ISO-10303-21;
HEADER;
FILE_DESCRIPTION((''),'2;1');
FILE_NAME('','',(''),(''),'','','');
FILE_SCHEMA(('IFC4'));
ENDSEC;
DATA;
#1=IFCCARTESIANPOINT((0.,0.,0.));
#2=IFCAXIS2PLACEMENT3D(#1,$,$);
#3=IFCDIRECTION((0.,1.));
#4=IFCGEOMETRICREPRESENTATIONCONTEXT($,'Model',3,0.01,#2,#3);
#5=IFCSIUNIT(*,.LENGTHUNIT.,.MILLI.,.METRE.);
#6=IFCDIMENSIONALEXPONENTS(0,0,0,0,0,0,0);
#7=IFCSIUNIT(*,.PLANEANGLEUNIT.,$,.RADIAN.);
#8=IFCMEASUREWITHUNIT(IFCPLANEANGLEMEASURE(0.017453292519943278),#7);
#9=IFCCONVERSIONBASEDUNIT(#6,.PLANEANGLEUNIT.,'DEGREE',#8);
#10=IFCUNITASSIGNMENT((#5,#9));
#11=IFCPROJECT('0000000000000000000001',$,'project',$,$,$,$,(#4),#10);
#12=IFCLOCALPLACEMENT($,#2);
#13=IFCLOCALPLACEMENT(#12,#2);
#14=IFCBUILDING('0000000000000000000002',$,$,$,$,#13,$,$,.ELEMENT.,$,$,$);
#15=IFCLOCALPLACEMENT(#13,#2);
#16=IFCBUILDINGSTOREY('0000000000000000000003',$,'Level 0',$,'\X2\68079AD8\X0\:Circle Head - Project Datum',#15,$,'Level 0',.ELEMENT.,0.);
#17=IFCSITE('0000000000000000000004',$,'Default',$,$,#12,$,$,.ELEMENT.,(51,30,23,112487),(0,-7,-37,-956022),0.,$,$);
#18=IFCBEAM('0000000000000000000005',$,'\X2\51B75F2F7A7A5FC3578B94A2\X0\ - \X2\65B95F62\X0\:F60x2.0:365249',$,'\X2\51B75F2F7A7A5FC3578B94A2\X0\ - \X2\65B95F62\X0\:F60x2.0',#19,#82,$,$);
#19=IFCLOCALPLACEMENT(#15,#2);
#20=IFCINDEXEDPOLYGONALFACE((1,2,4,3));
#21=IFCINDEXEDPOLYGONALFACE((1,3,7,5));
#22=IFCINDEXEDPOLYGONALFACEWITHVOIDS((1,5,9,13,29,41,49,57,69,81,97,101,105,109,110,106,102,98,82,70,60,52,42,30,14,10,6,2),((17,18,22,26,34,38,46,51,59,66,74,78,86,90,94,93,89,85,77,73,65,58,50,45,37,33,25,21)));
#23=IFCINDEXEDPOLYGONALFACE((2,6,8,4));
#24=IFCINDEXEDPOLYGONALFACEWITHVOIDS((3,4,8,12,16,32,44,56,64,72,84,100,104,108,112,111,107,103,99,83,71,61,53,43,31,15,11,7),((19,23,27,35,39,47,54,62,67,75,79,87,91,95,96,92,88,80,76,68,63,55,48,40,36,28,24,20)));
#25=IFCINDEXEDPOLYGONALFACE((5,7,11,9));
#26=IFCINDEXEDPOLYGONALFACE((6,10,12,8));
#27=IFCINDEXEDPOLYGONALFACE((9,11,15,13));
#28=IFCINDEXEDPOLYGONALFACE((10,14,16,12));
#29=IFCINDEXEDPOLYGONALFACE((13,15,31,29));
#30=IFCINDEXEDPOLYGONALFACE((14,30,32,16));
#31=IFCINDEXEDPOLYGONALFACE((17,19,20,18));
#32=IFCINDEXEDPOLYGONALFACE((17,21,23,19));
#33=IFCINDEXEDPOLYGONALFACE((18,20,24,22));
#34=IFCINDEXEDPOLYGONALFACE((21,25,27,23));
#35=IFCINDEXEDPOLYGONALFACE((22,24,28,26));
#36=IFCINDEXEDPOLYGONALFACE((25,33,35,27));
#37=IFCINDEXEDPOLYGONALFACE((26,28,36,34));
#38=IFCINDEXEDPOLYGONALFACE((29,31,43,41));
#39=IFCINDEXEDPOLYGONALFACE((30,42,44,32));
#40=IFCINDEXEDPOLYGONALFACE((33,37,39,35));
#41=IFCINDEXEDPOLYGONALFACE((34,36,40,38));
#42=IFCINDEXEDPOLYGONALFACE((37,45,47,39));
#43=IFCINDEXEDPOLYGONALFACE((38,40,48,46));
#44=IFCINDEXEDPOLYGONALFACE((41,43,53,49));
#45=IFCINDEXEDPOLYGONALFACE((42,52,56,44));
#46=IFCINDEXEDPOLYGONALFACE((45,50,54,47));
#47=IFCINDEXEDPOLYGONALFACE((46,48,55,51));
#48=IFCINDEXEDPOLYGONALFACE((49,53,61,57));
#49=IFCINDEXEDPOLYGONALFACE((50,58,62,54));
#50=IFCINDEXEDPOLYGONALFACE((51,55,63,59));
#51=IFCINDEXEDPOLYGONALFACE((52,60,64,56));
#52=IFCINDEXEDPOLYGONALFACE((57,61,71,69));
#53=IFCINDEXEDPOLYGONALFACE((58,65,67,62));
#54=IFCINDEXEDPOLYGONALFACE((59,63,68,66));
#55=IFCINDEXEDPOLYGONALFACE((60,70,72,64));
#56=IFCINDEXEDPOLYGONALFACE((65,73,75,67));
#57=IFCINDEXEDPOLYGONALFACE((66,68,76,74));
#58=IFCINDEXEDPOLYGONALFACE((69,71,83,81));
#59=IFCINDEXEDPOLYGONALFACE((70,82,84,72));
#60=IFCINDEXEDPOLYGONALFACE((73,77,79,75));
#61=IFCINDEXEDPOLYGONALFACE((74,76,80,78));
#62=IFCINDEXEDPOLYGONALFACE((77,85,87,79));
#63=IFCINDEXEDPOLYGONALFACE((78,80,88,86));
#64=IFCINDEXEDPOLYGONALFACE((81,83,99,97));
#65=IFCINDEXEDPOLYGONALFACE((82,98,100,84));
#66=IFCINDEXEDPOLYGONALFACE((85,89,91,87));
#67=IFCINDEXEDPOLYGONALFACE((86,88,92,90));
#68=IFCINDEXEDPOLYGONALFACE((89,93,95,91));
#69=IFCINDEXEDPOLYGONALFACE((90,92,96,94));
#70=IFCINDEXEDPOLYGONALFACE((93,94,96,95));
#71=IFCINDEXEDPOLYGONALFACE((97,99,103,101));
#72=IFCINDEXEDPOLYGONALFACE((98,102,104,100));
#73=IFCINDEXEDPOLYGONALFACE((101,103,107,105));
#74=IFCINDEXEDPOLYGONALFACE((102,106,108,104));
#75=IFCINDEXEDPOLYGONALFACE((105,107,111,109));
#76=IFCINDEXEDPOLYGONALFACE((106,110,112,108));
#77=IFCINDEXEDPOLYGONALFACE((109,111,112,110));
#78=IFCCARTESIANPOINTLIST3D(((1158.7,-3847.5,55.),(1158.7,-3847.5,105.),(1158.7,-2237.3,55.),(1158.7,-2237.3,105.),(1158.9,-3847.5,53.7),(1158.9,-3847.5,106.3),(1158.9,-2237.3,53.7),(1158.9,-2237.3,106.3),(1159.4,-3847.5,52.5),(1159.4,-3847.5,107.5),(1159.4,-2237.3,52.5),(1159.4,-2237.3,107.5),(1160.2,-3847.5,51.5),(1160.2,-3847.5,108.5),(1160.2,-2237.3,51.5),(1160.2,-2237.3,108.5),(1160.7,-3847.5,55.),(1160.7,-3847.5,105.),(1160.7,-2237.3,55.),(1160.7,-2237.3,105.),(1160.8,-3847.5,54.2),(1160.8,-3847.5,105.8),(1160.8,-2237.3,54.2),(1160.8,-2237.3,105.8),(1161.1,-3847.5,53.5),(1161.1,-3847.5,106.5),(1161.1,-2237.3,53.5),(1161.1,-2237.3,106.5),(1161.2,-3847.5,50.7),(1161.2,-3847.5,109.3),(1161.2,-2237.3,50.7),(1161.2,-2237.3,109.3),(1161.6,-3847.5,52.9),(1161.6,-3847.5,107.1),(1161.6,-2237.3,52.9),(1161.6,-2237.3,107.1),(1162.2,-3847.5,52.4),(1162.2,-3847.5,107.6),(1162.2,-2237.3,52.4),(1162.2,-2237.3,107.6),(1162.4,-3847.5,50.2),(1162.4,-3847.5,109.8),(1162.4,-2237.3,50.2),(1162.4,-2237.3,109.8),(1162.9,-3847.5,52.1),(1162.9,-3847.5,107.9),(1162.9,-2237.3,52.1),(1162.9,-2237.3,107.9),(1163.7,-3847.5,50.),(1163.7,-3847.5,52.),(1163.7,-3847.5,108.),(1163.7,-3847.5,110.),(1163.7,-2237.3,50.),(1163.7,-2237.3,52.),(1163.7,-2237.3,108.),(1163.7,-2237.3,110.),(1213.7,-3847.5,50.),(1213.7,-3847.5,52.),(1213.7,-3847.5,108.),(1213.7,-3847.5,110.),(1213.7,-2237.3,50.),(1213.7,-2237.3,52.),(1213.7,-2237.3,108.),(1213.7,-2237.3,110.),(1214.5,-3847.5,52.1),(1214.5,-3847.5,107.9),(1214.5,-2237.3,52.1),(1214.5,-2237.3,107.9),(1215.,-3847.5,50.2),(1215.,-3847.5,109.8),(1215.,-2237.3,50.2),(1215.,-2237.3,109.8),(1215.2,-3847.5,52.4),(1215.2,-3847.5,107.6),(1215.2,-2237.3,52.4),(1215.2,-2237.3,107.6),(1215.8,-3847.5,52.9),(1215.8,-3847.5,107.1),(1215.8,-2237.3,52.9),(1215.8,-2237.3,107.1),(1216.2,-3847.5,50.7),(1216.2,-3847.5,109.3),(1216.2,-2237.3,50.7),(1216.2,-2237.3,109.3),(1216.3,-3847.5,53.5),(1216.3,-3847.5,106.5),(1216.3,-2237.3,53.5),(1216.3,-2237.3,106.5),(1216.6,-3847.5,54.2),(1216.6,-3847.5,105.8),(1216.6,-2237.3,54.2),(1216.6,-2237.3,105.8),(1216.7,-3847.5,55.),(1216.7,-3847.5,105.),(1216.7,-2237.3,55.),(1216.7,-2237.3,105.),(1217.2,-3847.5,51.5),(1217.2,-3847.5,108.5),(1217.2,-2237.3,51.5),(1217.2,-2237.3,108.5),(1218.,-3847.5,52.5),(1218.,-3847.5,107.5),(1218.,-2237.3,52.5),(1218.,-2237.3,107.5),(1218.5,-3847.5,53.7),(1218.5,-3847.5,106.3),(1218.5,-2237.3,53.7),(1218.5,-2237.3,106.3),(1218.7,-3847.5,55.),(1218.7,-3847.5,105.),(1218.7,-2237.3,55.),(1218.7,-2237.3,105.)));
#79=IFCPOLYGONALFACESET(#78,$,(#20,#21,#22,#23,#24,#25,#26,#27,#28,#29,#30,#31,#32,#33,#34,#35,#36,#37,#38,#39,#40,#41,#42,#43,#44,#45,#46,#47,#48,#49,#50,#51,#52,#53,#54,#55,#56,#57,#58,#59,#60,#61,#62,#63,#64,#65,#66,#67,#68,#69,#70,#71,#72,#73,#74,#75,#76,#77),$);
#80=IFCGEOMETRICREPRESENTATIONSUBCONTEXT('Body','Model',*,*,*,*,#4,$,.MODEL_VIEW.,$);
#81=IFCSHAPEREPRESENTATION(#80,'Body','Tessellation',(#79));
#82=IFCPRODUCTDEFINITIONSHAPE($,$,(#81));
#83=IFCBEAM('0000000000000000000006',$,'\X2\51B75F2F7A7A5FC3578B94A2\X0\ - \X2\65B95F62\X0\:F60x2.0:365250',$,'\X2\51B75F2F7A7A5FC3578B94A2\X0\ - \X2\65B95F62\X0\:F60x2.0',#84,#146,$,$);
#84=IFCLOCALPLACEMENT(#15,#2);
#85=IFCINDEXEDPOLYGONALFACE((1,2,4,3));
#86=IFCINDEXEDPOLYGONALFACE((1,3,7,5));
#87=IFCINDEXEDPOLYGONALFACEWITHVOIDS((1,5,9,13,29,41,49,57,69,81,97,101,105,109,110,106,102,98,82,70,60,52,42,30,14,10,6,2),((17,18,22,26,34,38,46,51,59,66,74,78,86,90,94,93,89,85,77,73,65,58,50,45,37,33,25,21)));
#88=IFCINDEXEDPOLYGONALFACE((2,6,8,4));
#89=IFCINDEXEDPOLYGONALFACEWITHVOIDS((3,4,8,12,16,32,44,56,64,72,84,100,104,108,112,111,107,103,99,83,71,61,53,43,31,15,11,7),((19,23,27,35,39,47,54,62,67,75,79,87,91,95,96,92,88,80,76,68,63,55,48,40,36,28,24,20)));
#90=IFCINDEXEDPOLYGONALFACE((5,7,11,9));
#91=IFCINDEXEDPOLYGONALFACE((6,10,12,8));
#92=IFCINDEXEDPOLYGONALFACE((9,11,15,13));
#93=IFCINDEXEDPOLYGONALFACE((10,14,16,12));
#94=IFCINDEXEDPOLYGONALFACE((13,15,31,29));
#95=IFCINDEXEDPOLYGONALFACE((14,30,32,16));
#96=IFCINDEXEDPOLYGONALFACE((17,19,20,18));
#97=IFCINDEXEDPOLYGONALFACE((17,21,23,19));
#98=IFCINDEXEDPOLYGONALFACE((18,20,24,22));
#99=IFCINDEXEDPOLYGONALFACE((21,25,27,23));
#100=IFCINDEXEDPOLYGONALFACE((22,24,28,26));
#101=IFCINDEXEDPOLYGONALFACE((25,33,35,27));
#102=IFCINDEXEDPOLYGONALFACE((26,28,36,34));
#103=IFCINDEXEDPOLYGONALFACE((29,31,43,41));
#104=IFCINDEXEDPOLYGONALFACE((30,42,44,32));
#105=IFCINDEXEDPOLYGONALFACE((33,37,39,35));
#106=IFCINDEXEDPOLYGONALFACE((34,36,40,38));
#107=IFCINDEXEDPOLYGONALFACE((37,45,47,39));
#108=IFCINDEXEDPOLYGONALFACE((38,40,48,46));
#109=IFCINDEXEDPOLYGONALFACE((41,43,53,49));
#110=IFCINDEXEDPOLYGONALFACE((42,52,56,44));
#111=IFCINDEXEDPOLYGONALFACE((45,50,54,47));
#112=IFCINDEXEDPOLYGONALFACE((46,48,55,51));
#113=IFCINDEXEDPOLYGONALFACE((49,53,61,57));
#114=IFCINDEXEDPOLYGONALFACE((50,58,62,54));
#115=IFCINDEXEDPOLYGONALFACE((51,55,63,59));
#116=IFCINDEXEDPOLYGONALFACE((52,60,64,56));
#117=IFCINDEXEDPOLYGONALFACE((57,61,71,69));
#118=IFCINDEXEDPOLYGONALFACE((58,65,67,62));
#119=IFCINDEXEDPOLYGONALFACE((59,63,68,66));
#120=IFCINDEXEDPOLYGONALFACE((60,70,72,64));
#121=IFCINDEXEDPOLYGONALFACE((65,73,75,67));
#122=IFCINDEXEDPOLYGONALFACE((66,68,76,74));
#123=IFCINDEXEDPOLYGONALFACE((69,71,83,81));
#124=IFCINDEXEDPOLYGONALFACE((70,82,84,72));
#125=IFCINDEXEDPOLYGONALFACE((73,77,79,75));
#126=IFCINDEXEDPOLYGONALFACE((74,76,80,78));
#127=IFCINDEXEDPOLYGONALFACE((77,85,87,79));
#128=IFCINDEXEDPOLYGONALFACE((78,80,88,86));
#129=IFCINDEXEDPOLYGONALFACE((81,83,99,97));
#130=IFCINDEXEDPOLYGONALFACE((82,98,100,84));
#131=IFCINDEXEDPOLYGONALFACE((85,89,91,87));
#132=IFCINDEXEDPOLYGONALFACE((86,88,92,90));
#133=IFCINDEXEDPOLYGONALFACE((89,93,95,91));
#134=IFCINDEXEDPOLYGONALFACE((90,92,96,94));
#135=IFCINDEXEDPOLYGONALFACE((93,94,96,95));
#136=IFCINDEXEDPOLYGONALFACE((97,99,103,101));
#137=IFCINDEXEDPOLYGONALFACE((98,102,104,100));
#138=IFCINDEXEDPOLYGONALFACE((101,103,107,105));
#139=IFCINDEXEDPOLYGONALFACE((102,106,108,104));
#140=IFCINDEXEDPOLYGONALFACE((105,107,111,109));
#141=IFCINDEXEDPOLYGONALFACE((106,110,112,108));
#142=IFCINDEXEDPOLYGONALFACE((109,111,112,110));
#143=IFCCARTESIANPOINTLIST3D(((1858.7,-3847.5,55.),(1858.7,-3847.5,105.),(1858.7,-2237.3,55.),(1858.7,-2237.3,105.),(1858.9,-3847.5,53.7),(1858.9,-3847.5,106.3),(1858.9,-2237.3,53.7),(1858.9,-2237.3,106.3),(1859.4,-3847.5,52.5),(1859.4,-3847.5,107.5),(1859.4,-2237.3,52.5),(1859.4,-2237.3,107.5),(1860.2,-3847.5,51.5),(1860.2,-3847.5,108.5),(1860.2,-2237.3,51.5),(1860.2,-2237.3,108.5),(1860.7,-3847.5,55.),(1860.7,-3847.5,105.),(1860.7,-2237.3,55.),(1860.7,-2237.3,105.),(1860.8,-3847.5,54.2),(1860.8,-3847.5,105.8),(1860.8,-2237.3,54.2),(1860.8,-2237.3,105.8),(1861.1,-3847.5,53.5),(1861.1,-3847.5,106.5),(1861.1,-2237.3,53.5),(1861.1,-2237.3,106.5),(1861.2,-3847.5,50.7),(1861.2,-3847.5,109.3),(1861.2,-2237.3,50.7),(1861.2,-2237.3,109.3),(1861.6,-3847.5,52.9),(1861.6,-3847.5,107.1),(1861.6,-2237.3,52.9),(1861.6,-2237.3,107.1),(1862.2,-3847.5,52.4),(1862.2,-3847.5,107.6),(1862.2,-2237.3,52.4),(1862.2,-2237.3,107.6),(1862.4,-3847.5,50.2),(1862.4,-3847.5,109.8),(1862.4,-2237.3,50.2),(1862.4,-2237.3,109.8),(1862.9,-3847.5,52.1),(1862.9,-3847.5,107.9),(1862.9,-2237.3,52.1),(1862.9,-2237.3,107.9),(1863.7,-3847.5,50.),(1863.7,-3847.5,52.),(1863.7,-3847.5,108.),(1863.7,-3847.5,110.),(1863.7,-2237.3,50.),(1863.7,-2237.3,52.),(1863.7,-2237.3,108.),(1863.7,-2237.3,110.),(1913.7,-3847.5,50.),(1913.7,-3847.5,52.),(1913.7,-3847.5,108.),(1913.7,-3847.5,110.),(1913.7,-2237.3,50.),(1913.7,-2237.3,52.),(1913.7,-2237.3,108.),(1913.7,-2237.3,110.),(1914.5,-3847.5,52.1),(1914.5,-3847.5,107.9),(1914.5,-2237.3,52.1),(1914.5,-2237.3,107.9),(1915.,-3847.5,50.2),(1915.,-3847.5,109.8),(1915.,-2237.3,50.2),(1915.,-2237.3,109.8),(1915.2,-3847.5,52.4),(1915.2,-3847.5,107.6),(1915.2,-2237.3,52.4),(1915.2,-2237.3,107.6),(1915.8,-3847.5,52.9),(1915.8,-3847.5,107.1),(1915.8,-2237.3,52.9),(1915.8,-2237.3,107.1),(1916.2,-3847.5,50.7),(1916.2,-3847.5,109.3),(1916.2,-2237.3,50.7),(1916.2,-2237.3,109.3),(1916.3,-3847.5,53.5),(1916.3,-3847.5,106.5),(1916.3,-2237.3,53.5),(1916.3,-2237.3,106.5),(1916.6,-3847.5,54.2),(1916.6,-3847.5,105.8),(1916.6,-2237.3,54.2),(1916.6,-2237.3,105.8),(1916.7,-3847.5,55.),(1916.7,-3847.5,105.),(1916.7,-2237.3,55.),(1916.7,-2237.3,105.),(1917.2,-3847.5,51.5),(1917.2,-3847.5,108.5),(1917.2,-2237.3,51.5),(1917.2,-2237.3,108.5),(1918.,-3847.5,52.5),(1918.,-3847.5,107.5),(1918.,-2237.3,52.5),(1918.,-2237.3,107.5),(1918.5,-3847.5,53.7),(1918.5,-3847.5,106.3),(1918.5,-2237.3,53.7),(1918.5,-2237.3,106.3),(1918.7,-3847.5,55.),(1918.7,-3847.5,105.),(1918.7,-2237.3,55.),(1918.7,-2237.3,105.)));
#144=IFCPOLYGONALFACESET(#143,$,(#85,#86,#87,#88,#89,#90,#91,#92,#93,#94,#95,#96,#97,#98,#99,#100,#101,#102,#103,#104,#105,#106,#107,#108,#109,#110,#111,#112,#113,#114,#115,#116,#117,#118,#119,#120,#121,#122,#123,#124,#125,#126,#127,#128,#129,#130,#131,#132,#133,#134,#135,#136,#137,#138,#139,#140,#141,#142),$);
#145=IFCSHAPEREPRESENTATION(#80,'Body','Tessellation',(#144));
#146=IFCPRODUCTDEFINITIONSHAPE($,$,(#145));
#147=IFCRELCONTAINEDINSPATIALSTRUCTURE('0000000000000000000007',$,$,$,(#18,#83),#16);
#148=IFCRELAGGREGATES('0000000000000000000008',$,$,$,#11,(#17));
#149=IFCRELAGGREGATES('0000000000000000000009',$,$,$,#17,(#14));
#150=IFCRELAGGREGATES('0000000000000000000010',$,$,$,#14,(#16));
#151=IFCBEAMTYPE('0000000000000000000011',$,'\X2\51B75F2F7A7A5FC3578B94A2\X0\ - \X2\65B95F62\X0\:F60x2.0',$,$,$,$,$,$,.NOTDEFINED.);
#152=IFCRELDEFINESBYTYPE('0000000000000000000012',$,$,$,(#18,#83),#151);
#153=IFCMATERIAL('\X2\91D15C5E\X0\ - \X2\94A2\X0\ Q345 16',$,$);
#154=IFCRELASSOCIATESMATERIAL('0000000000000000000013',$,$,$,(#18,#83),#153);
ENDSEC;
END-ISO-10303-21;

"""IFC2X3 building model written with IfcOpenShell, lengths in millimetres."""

from ifc_helpers import new_model, entity, si_unit, converted_unit, direction, frame, frame_2d, origin, place, context, subcontext, project, spatial, polyline, circle_curve, parameter, trimmed, segment, composite_curve, outline, extrude, material, type_object, element, save


model = new_model("IFC2X3")

# Units and contexts
model_context = context("Model", 3, precision=0.01, world=origin(), true_north=direction((0.0, 1.0)))
body_context = subcontext(model_context, "Body", "Model", "MODEL_VIEW")
ifc_project = project(units=[si_unit("LENGTHUNIT", "METRE", prefix="MILLI"), converted_unit("PLANEANGLEUNIT", "DEGREE", entity("IfcPlaneAngleMeasure", 0.017453292519943278), si_unit("PLANEANGLEUNIT", "RADIAN"), dimensions=[0, 0, 0, 0, 0, 0, 0])], contexts=[model_context])

# Site, building, storey
site_placement = place(None, origin())
site = spatial("IfcSite", under=ifc_project, at=site_placement, Name="Default", CompositionType="ELEMENT", RefLatitude=(51, 30, 23, 112487), RefLongitude=(0, -7, -37, -956022), RefElevation=0.0)
building_placement = place(site_placement, origin())
building = spatial("IfcBuilding", under=site, at=building_placement, CompositionType="ELEMENT")
storey_placement = place(building_placement, origin())
storey = spatial("IfcBuildingStorey", under=building, at=storey_placement, Name="Level 0", ObjectType="标高:Circle Head - Project Datum", LongName="Level 0", CompositionType="ELEMENT", Elevation=0.0)

# Beams
ifc_material_1 = material(Name="金属 - 钢 Q345 16")
beam_type_1 = type_object("IfcBeamType", Name="冷弯空心型钢 - 方形:F60x2.0", PredefinedType="NOTDEFINED")
beam_1_placement = place(storey_placement, frame((1188.7, -3815.6, 110.0), z_axis=(0.0, 0.0, 1.0), x_axis=(0.0, 1.0, 0.0)))
element("IfcBeam", 1, at=beam_1_placement, inside=storey, type_object=beam_type_1, material=ifc_material_1, Name="冷弯空心型钢 - 方形:F60x2.0:365249", ObjectType="冷弯空心型钢 - 方形:F60x2.0", context=body_context, shape_type="SweptSolid", body=[
    extrude(outline(composite_curve([segment(polyline([(-25.0, -30.0), (25.0, -30.0)]), True, "CONTINUOUS"), segment(trimmed(circle_curve(frame_2d((25.0, -25.0), x_axis=(1.0, 0.0)), 5.0), [parameter(270.0)], [parameter(360.0)], True, "PARAMETER"), True, "CONTINUOUS"), segment(polyline([(30.0, -25.0), (30.0, 25.0)]), True, "CONTINUOUS"), segment(trimmed(circle_curve(frame_2d((25.0, 25.0), x_axis=(1.0, 0.0)), 5.0), [parameter(360.0)], [parameter(90.0)], True, "PARAMETER"), True, "CONTINUOUS"), segment(polyline([(25.0, 30.0), (-25.0, 30.0)]), True, "CONTINUOUS"), segment(trimmed(circle_curve(frame_2d((-25.0, 25.0), x_axis=(1.0, 0.0)), 5.0), [parameter(90.0)], [parameter(180.0)], True, "PARAMETER"), True, "CONTINUOUS"), segment(polyline([(-30.0, 25.0), (-30.0, -25.0)]), True, "CONTINUOUS"), segment(trimmed(circle_curve(frame_2d((-25.0, -25.0), x_axis=(1.0, 0.0)), 5.0), [parameter(180.0)], [parameter(270.0)], True, "PARAMETER"), True, "CONTINUOUS")], self_intersect=False), holes=[composite_curve([segment(trimmed(circle_curve(frame_2d((-25.0, -25.0), x_axis=(1.0, 0.0)), 3.0), [parameter(180.0)], [parameter(270.0)], True, "PARAMETER"), False, "CONTINUOUS"), segment(polyline([(-28.0, -25.0), (-28.0, 25.0)]), True, "CONTINUOUS"), segment(trimmed(circle_curve(frame_2d((-25.0, 25.0), x_axis=(1.0, 0.0)), 3.0), [parameter(90.0)], [parameter(180.0)], True, "PARAMETER"), False, "CONTINUOUS"), segment(polyline([(-25.0, 28.0), (25.0, 28.0)]), True, "CONTINUOUS"), segment(trimmed(circle_curve(frame_2d((25.0, 25.0), x_axis=(1.0, 0.0)), 3.0), [parameter(0.0)], [parameter(90.0)], True, "PARAMETER"), False, "CONTINUOUS"), segment(polyline([(28.0, 25.0), (28.0, -25.0)]), True, "CONTINUOUS"), segment(trimmed(circle_curve(frame_2d((25.0, -25.0), x_axis=(1.0, 0.0)), 3.0), [parameter(270.0)], [parameter(360.0)], True, "PARAMETER"), False, "CONTINUOUS"), segment(polyline([(25.0, -28.0), (-25.0, -28.0)]), True, "CONTINUOUS")], self_intersect=False)]), frame((-31.9, 0.0, -30.0), z_axis=(1.0, 0.0, 0.0), x_axis=(0.0, -1.0, 0.0)), (0.0, 0.0, 1.0), 1610.2),
])
beam_2_placement = place(storey_placement, frame((1888.7, -3815.6, 110.0), z_axis=(0.0, 0.0, 1.0), x_axis=(0.0, 1.0, 0.0)))
element("IfcBeam", 2, at=beam_2_placement, inside=storey, type_object=beam_type_1, material=ifc_material_1, Name="冷弯空心型钢 - 方形:F60x2.0:365250", ObjectType="冷弯空心型钢 - 方形:F60x2.0", context=body_context, shape_type="SweptSolid", body=[
    extrude(outline(composite_curve([segment(polyline([(-25.0, -30.0), (25.0, -30.0)]), True, "CONTINUOUS"), segment(trimmed(circle_curve(frame_2d((25.0, -25.0), x_axis=(1.0, 0.0)), 5.0), [parameter(270.0)], [parameter(360.0)], True, "PARAMETER"), True, "CONTINUOUS"), segment(polyline([(30.0, -25.0), (30.0, 25.0)]), True, "CONTINUOUS"), segment(trimmed(circle_curve(frame_2d((25.0, 25.0), x_axis=(1.0, 0.0)), 5.0), [parameter(360.0)], [parameter(90.0)], True, "PARAMETER"), True, "CONTINUOUS"), segment(polyline([(25.0, 30.0), (-25.0, 30.0)]), True, "CONTINUOUS"), segment(trimmed(circle_curve(frame_2d((-25.0, 25.0), x_axis=(1.0, 0.0)), 5.0), [parameter(90.0)], [parameter(180.0)], True, "PARAMETER"), True, "CONTINUOUS"), segment(polyline([(-30.0, 25.0), (-30.0, -25.0)]), True, "CONTINUOUS"), segment(trimmed(circle_curve(frame_2d((-25.0, -25.0), x_axis=(1.0, 0.0)), 5.0), [parameter(180.0)], [parameter(270.0)], True, "PARAMETER"), True, "CONTINUOUS")], self_intersect=False), holes=[composite_curve([segment(trimmed(circle_curve(frame_2d((-25.0, -25.0), x_axis=(1.0, 0.0)), 3.0), [parameter(180.0)], [parameter(270.0)], True, "PARAMETER"), False, "CONTINUOUS"), segment(polyline([(-28.0, -25.0), (-28.0, 25.0)]), True, "CONTINUOUS"), segment(trimmed(circle_curve(frame_2d((-25.0, 25.0), x_axis=(1.0, 0.0)), 3.0), [parameter(90.0)], [parameter(180.0)], True, "PARAMETER"), False, "CONTINUOUS"), segment(polyline([(-25.0, 28.0), (25.0, 28.0)]), True, "CONTINUOUS"), segment(trimmed(circle_curve(frame_2d((25.0, 25.0), x_axis=(1.0, 0.0)), 3.0), [parameter(0.0)], [parameter(90.0)], True, "PARAMETER"), False, "CONTINUOUS"), segment(polyline([(28.0, 25.0), (28.0, -25.0)]), True, "CONTINUOUS"), segment(trimmed(circle_curve(frame_2d((25.0, -25.0), x_axis=(1.0, 0.0)), 3.0), [parameter(270.0)], [parameter(360.0)], True, "PARAMETER"), False, "CONTINUOUS"), segment(polyline([(25.0, -28.0), (-25.0, -28.0)]), True, "CONTINUOUS")], self_intersect=False)]), frame((-31.9, 0.0, -30.0), z_axis=(1.0, 0.0, 0.0), x_axis=(0.0, -1.0, 0.0)), (0.0, 0.0, 1.0), 1610.2),
])

save(model, "model.ifc")
